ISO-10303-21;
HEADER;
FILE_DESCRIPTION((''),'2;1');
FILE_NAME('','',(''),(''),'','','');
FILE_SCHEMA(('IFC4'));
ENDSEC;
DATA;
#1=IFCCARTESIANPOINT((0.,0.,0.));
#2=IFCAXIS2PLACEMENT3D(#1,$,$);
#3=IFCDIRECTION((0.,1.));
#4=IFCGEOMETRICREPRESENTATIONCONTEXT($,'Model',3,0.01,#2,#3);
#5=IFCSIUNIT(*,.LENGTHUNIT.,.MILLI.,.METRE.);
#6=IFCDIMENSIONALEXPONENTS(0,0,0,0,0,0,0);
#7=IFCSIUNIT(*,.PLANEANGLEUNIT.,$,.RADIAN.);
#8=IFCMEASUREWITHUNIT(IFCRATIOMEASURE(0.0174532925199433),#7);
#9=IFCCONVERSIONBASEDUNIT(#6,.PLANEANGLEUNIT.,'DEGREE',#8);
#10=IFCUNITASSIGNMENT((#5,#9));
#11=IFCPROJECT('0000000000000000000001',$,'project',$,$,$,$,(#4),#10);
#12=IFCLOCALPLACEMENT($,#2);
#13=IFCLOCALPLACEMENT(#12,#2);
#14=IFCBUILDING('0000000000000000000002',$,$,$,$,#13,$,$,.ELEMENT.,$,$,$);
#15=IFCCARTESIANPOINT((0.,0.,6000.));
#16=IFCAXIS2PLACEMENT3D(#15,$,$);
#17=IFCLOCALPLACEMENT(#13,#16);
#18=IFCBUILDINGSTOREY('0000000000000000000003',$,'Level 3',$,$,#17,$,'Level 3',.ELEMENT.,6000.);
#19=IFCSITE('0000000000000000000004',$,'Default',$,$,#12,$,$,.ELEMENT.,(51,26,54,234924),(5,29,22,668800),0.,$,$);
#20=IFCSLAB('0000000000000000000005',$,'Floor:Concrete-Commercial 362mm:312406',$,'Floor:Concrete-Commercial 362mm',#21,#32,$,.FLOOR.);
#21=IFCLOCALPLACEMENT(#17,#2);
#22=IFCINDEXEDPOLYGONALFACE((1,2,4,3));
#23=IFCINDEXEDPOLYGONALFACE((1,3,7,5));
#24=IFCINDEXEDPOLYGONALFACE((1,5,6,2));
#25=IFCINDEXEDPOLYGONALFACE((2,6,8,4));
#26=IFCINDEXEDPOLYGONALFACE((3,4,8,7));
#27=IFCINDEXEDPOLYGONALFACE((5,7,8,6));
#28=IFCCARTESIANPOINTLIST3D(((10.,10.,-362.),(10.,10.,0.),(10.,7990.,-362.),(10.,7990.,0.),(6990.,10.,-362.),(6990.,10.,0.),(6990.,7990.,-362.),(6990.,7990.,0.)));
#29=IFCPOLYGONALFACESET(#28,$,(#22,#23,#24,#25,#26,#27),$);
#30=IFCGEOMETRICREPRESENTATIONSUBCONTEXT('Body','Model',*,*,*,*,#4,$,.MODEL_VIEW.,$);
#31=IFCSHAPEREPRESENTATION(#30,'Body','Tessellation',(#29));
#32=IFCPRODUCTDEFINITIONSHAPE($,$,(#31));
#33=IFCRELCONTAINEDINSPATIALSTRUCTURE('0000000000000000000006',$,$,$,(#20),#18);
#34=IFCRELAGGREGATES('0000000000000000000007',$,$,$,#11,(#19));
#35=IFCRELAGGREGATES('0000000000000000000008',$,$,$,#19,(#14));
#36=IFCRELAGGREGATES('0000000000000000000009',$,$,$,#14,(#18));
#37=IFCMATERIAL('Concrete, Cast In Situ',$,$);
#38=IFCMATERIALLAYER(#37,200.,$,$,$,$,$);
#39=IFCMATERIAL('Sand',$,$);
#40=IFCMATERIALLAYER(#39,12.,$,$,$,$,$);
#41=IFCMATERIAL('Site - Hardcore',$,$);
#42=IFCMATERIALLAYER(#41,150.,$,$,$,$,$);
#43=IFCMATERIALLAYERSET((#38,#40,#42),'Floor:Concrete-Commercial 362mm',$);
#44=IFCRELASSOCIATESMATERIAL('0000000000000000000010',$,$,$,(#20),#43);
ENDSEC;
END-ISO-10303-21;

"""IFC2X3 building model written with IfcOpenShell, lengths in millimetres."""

from ifc_helpers import new_model, entity, si_unit, converted_unit, direction, frame, frame_2d, origin, place, context, subcontext, project, spatial, rectangle, extrude, material, layer, layer_set, layer_usage, element, save


model = new_model("IFC2X3")

# Units and contexts
model_context = context("Model", 3, precision=0.01, world=origin(), true_north=direction((0.0, 1.0)))
body_context = subcontext(model_context, "Body", "Model", "MODEL_VIEW")
ifc_project = project(units=[si_unit("LENGTHUNIT", "METRE", prefix="MILLI"), converted_unit("PLANEANGLEUNIT", "DEGREE", entity("IfcRatioMeasure", 0.0174532925199433), si_unit("PLANEANGLEUNIT", "RADIAN"), dimensions=[0, 0, 0, 0, 0, 0, 0])], contexts=[model_context])

# Site, building, storey
site_placement = place(None, origin())
site = spatial("IfcSite", under=ifc_project, at=site_placement, Name="Default", CompositionType="ELEMENT", RefLatitude=(51, 26, 54, 234924), RefLongitude=(5, 29, 22, 668800), RefElevation=0.0)
building_placement = place(site_placement, origin())
building = spatial("IfcBuilding", under=site, at=building_placement, CompositionType="ELEMENT")
storey_placement = place(building_placement, frame((0.0, 0.0, 6000.0)))
storey = spatial("IfcBuildingStorey", under=building, at=storey_placement, Name="Level 3", LongName="Level 3", CompositionType="ELEMENT", Elevation=6000.0)

# Slab
ifc_material_1 = material(Name="Concrete, Cast In Situ")
ifc_layer_1 = layer(ifc_material_1, 200.0)
ifc_material_2 = material(Name="Sand")
ifc_layer_2 = layer(ifc_material_2, 12.0)
ifc_material_3 = material(Name="Site - Hardcore")
ifc_layer_3 = layer(ifc_material_3, 150.0)
ifc_layer_set = layer_set([ifc_layer_1, ifc_layer_2, ifc_layer_3], Name="Floor:Concrete-Commercial 362mm")
ifc_layer_usage = layer_usage(ifc_layer_set, "AXIS3", "POSITIVE", 0.0)
slab_placement = place(storey_placement, origin())
element("IfcSlab", 1, at=slab_placement, inside=storey, material=ifc_layer_usage, Name="Floor:Concrete-Commercial 362mm:312406", ObjectType="Floor:Concrete-Commercial 362mm", PredefinedType="FLOOR", context=body_context, shape_type="SweptSolid", body=[
    extrude(rectangle(XDim=7980.0, YDim=6980.0, at=frame_2d((0.0, 0.0), x_axis=(1.0, 0.0))), frame((3500.0, 4000.0, 0.0), z_axis=(0.0, 0.0, -1.0), x_axis=(0.0, 1.0, 0.0)), (0.0, 0.0, 1.0), 362.0),
])

save(model, "model.ifc")
